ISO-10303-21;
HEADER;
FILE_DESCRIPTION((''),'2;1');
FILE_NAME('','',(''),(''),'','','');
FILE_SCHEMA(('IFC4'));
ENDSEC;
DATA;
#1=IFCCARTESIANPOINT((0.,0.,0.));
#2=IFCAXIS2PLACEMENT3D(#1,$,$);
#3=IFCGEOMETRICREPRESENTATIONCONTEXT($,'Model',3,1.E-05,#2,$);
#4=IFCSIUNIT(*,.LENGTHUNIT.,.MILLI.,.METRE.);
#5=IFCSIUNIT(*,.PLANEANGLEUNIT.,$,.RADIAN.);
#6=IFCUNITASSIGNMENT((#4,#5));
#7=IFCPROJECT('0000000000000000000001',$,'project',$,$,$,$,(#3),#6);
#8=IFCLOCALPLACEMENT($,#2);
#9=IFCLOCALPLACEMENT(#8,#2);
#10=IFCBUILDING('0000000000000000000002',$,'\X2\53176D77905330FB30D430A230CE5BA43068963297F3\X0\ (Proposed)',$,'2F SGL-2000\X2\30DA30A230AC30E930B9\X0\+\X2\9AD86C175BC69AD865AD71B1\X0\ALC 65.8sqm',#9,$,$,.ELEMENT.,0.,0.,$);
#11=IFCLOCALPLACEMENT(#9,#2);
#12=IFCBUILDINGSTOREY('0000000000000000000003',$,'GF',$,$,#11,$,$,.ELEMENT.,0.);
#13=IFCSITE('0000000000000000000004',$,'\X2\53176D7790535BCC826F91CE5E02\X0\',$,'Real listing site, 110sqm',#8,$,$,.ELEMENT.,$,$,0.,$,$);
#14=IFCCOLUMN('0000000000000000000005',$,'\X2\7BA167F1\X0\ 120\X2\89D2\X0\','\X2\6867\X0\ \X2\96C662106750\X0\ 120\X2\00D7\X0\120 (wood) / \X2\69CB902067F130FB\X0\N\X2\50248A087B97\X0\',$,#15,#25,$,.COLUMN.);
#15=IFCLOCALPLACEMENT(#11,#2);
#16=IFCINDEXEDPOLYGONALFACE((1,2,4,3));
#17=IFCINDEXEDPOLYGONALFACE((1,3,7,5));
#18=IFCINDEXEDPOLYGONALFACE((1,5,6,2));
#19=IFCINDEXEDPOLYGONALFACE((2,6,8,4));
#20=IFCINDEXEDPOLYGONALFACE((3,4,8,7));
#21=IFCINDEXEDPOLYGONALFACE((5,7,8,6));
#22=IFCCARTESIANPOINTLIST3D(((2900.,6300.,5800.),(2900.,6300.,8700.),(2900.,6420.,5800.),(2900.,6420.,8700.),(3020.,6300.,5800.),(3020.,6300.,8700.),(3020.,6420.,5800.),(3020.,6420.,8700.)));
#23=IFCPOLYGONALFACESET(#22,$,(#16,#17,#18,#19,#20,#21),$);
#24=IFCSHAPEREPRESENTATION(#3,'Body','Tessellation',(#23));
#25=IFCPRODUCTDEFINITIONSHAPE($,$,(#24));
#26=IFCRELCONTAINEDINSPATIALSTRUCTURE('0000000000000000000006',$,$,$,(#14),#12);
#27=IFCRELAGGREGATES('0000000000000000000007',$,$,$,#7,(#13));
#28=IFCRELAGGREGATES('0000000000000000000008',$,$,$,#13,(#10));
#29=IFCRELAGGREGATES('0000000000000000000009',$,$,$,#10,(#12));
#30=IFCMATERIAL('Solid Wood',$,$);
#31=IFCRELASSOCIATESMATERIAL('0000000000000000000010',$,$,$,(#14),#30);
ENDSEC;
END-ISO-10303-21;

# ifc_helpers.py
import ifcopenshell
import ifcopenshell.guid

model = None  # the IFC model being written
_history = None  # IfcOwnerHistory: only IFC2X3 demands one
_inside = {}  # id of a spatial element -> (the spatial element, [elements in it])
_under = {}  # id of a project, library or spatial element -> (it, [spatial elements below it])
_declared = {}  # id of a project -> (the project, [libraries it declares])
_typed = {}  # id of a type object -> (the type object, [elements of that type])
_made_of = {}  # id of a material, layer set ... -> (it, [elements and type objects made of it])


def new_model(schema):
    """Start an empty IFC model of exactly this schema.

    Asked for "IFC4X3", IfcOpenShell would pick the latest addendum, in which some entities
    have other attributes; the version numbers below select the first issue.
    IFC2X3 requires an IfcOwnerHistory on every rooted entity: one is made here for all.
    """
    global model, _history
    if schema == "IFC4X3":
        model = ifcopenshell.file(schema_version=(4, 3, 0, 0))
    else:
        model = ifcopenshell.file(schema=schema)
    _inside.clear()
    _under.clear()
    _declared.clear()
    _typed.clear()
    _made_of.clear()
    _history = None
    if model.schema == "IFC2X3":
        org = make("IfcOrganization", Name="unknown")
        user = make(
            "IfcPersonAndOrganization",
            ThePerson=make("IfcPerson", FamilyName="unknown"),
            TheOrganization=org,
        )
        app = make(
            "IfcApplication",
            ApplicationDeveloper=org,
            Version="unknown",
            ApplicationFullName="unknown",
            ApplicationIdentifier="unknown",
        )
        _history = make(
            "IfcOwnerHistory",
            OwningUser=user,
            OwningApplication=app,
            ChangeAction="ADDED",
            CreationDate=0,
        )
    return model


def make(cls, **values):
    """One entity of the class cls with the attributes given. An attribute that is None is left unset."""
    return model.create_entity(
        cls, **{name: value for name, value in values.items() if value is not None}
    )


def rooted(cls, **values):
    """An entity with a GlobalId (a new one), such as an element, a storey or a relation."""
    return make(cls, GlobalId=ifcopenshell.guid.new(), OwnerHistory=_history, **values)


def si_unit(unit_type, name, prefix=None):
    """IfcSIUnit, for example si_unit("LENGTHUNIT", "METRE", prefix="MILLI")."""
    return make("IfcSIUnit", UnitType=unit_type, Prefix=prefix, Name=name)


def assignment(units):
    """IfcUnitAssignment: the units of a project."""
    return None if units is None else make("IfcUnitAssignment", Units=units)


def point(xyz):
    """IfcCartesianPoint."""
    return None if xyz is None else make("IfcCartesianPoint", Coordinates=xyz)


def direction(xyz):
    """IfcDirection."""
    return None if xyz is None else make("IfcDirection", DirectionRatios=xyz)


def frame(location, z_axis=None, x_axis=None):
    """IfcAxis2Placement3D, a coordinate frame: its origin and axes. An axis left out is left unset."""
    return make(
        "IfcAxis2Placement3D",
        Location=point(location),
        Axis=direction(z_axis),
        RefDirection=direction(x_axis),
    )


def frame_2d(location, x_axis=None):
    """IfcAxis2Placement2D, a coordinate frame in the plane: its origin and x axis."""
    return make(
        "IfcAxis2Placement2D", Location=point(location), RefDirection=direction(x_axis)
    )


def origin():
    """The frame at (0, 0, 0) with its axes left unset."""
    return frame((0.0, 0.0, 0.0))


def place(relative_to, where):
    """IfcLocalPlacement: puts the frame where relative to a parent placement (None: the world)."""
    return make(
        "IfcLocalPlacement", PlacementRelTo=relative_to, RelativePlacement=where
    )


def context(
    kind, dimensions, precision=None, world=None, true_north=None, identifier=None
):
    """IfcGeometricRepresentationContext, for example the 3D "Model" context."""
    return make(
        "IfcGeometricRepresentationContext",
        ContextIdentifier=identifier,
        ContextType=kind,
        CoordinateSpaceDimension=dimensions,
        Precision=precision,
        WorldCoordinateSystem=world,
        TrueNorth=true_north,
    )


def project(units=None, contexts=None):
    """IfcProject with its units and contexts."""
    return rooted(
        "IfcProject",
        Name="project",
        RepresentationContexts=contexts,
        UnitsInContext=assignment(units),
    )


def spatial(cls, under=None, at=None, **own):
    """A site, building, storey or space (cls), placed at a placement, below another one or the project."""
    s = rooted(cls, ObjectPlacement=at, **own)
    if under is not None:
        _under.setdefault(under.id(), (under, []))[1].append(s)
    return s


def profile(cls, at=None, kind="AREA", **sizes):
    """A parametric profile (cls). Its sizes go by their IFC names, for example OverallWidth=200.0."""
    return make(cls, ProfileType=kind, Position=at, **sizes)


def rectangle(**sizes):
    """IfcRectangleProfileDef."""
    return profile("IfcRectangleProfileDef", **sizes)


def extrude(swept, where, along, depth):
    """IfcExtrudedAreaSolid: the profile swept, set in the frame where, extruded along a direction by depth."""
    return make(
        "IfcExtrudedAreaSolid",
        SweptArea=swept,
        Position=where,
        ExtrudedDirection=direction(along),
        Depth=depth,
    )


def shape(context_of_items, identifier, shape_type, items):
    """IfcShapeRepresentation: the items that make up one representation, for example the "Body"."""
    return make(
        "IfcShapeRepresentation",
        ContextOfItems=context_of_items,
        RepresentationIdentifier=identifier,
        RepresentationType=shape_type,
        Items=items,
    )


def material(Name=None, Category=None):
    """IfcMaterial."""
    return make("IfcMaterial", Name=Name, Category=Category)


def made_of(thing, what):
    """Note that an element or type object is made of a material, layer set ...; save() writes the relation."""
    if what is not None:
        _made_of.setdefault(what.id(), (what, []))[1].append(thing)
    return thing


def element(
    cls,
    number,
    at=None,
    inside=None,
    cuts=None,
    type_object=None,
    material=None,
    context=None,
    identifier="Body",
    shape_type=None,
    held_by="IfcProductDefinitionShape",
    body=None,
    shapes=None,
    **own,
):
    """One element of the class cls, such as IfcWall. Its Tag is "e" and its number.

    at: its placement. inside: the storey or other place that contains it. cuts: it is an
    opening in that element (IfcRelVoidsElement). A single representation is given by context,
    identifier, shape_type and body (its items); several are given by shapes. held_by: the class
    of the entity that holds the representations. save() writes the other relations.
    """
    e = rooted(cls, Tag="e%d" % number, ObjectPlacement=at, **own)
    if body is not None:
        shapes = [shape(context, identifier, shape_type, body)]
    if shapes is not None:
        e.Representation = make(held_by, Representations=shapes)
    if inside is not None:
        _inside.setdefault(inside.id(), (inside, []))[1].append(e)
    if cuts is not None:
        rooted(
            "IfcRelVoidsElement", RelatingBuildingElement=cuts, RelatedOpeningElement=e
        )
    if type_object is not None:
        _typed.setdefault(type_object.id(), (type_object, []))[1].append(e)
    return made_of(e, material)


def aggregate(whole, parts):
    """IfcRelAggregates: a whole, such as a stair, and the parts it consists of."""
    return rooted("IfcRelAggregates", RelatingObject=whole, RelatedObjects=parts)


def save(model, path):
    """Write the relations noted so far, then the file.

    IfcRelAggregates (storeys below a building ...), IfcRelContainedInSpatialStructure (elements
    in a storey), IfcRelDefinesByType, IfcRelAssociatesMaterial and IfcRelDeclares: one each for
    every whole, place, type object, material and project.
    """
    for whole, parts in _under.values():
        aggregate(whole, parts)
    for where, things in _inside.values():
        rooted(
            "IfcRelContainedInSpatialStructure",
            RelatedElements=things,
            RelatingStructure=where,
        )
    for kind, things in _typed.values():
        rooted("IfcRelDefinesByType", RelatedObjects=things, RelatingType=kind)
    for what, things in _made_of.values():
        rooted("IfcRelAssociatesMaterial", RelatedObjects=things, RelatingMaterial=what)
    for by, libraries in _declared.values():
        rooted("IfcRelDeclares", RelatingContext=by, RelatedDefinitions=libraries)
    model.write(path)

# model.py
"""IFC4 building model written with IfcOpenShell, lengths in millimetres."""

from ifc_helpers import new_model, si_unit, frame, frame_2d, origin, place, context, project, spatial, rectangle, extrude, material, element, save


model = new_model("IFC4")

# Units and contexts
model_context = context("Model", 3, precision=1e-05, world=origin())
ifc_project = project(units=[si_unit("LENGTHUNIT", "METRE", prefix="MILLI"), si_unit("PLANEANGLEUNIT", "RADIAN")], contexts=[model_context])

# Site, building, storey
site_placement = place(None, origin())
site = spatial("IfcSite", under=ifc_project, at=site_placement, Name="北海道富良野市", ObjectType="Real listing site, 110sqm", CompositionType="ELEMENT", RefElevation=0.0)
building_placement = place(site_placement, origin())
building = spatial("IfcBuilding", under=site, at=building_placement, Name="北海道・ピアノ室と防音 (Proposed)", ObjectType="2F SGL-2000ペアガラス+高気密高断熱ALC 65.8sqm", CompositionType="ELEMENT", ElevationOfRefHeight=0.0, ElevationOfTerrain=0.0)
storey_placement = place(building_placement, origin())
storey = spatial("IfcBuildingStorey", under=building, at=storey_placement, Name="GF", CompositionType="ELEMENT", Elevation=0.0)

# Column
ifc_material_1 = material(Name="Solid Wood")
column_1_placement = place(storey_placement, frame((1450.0, 3150.0, 2900.0)))
element("IfcColumn", 1, at=column_1_placement, inside=storey, material=ifc_material_1, Name="管柱 120角", Description="桧 集成材 120×120 (wood) / 構造柱・N値計算", PredefinedType="COLUMN", context=model_context, shape_type="SweptSolid", body=[
    extrude(rectangle(XDim=120.0, YDim=120.0, at=frame_2d((60.0, 60.0))), frame((1450.0, 3150.0, 2900.0)), (0.0, 0.0, 1.0), 2900.0),
])

save(model, "model.ifc")
